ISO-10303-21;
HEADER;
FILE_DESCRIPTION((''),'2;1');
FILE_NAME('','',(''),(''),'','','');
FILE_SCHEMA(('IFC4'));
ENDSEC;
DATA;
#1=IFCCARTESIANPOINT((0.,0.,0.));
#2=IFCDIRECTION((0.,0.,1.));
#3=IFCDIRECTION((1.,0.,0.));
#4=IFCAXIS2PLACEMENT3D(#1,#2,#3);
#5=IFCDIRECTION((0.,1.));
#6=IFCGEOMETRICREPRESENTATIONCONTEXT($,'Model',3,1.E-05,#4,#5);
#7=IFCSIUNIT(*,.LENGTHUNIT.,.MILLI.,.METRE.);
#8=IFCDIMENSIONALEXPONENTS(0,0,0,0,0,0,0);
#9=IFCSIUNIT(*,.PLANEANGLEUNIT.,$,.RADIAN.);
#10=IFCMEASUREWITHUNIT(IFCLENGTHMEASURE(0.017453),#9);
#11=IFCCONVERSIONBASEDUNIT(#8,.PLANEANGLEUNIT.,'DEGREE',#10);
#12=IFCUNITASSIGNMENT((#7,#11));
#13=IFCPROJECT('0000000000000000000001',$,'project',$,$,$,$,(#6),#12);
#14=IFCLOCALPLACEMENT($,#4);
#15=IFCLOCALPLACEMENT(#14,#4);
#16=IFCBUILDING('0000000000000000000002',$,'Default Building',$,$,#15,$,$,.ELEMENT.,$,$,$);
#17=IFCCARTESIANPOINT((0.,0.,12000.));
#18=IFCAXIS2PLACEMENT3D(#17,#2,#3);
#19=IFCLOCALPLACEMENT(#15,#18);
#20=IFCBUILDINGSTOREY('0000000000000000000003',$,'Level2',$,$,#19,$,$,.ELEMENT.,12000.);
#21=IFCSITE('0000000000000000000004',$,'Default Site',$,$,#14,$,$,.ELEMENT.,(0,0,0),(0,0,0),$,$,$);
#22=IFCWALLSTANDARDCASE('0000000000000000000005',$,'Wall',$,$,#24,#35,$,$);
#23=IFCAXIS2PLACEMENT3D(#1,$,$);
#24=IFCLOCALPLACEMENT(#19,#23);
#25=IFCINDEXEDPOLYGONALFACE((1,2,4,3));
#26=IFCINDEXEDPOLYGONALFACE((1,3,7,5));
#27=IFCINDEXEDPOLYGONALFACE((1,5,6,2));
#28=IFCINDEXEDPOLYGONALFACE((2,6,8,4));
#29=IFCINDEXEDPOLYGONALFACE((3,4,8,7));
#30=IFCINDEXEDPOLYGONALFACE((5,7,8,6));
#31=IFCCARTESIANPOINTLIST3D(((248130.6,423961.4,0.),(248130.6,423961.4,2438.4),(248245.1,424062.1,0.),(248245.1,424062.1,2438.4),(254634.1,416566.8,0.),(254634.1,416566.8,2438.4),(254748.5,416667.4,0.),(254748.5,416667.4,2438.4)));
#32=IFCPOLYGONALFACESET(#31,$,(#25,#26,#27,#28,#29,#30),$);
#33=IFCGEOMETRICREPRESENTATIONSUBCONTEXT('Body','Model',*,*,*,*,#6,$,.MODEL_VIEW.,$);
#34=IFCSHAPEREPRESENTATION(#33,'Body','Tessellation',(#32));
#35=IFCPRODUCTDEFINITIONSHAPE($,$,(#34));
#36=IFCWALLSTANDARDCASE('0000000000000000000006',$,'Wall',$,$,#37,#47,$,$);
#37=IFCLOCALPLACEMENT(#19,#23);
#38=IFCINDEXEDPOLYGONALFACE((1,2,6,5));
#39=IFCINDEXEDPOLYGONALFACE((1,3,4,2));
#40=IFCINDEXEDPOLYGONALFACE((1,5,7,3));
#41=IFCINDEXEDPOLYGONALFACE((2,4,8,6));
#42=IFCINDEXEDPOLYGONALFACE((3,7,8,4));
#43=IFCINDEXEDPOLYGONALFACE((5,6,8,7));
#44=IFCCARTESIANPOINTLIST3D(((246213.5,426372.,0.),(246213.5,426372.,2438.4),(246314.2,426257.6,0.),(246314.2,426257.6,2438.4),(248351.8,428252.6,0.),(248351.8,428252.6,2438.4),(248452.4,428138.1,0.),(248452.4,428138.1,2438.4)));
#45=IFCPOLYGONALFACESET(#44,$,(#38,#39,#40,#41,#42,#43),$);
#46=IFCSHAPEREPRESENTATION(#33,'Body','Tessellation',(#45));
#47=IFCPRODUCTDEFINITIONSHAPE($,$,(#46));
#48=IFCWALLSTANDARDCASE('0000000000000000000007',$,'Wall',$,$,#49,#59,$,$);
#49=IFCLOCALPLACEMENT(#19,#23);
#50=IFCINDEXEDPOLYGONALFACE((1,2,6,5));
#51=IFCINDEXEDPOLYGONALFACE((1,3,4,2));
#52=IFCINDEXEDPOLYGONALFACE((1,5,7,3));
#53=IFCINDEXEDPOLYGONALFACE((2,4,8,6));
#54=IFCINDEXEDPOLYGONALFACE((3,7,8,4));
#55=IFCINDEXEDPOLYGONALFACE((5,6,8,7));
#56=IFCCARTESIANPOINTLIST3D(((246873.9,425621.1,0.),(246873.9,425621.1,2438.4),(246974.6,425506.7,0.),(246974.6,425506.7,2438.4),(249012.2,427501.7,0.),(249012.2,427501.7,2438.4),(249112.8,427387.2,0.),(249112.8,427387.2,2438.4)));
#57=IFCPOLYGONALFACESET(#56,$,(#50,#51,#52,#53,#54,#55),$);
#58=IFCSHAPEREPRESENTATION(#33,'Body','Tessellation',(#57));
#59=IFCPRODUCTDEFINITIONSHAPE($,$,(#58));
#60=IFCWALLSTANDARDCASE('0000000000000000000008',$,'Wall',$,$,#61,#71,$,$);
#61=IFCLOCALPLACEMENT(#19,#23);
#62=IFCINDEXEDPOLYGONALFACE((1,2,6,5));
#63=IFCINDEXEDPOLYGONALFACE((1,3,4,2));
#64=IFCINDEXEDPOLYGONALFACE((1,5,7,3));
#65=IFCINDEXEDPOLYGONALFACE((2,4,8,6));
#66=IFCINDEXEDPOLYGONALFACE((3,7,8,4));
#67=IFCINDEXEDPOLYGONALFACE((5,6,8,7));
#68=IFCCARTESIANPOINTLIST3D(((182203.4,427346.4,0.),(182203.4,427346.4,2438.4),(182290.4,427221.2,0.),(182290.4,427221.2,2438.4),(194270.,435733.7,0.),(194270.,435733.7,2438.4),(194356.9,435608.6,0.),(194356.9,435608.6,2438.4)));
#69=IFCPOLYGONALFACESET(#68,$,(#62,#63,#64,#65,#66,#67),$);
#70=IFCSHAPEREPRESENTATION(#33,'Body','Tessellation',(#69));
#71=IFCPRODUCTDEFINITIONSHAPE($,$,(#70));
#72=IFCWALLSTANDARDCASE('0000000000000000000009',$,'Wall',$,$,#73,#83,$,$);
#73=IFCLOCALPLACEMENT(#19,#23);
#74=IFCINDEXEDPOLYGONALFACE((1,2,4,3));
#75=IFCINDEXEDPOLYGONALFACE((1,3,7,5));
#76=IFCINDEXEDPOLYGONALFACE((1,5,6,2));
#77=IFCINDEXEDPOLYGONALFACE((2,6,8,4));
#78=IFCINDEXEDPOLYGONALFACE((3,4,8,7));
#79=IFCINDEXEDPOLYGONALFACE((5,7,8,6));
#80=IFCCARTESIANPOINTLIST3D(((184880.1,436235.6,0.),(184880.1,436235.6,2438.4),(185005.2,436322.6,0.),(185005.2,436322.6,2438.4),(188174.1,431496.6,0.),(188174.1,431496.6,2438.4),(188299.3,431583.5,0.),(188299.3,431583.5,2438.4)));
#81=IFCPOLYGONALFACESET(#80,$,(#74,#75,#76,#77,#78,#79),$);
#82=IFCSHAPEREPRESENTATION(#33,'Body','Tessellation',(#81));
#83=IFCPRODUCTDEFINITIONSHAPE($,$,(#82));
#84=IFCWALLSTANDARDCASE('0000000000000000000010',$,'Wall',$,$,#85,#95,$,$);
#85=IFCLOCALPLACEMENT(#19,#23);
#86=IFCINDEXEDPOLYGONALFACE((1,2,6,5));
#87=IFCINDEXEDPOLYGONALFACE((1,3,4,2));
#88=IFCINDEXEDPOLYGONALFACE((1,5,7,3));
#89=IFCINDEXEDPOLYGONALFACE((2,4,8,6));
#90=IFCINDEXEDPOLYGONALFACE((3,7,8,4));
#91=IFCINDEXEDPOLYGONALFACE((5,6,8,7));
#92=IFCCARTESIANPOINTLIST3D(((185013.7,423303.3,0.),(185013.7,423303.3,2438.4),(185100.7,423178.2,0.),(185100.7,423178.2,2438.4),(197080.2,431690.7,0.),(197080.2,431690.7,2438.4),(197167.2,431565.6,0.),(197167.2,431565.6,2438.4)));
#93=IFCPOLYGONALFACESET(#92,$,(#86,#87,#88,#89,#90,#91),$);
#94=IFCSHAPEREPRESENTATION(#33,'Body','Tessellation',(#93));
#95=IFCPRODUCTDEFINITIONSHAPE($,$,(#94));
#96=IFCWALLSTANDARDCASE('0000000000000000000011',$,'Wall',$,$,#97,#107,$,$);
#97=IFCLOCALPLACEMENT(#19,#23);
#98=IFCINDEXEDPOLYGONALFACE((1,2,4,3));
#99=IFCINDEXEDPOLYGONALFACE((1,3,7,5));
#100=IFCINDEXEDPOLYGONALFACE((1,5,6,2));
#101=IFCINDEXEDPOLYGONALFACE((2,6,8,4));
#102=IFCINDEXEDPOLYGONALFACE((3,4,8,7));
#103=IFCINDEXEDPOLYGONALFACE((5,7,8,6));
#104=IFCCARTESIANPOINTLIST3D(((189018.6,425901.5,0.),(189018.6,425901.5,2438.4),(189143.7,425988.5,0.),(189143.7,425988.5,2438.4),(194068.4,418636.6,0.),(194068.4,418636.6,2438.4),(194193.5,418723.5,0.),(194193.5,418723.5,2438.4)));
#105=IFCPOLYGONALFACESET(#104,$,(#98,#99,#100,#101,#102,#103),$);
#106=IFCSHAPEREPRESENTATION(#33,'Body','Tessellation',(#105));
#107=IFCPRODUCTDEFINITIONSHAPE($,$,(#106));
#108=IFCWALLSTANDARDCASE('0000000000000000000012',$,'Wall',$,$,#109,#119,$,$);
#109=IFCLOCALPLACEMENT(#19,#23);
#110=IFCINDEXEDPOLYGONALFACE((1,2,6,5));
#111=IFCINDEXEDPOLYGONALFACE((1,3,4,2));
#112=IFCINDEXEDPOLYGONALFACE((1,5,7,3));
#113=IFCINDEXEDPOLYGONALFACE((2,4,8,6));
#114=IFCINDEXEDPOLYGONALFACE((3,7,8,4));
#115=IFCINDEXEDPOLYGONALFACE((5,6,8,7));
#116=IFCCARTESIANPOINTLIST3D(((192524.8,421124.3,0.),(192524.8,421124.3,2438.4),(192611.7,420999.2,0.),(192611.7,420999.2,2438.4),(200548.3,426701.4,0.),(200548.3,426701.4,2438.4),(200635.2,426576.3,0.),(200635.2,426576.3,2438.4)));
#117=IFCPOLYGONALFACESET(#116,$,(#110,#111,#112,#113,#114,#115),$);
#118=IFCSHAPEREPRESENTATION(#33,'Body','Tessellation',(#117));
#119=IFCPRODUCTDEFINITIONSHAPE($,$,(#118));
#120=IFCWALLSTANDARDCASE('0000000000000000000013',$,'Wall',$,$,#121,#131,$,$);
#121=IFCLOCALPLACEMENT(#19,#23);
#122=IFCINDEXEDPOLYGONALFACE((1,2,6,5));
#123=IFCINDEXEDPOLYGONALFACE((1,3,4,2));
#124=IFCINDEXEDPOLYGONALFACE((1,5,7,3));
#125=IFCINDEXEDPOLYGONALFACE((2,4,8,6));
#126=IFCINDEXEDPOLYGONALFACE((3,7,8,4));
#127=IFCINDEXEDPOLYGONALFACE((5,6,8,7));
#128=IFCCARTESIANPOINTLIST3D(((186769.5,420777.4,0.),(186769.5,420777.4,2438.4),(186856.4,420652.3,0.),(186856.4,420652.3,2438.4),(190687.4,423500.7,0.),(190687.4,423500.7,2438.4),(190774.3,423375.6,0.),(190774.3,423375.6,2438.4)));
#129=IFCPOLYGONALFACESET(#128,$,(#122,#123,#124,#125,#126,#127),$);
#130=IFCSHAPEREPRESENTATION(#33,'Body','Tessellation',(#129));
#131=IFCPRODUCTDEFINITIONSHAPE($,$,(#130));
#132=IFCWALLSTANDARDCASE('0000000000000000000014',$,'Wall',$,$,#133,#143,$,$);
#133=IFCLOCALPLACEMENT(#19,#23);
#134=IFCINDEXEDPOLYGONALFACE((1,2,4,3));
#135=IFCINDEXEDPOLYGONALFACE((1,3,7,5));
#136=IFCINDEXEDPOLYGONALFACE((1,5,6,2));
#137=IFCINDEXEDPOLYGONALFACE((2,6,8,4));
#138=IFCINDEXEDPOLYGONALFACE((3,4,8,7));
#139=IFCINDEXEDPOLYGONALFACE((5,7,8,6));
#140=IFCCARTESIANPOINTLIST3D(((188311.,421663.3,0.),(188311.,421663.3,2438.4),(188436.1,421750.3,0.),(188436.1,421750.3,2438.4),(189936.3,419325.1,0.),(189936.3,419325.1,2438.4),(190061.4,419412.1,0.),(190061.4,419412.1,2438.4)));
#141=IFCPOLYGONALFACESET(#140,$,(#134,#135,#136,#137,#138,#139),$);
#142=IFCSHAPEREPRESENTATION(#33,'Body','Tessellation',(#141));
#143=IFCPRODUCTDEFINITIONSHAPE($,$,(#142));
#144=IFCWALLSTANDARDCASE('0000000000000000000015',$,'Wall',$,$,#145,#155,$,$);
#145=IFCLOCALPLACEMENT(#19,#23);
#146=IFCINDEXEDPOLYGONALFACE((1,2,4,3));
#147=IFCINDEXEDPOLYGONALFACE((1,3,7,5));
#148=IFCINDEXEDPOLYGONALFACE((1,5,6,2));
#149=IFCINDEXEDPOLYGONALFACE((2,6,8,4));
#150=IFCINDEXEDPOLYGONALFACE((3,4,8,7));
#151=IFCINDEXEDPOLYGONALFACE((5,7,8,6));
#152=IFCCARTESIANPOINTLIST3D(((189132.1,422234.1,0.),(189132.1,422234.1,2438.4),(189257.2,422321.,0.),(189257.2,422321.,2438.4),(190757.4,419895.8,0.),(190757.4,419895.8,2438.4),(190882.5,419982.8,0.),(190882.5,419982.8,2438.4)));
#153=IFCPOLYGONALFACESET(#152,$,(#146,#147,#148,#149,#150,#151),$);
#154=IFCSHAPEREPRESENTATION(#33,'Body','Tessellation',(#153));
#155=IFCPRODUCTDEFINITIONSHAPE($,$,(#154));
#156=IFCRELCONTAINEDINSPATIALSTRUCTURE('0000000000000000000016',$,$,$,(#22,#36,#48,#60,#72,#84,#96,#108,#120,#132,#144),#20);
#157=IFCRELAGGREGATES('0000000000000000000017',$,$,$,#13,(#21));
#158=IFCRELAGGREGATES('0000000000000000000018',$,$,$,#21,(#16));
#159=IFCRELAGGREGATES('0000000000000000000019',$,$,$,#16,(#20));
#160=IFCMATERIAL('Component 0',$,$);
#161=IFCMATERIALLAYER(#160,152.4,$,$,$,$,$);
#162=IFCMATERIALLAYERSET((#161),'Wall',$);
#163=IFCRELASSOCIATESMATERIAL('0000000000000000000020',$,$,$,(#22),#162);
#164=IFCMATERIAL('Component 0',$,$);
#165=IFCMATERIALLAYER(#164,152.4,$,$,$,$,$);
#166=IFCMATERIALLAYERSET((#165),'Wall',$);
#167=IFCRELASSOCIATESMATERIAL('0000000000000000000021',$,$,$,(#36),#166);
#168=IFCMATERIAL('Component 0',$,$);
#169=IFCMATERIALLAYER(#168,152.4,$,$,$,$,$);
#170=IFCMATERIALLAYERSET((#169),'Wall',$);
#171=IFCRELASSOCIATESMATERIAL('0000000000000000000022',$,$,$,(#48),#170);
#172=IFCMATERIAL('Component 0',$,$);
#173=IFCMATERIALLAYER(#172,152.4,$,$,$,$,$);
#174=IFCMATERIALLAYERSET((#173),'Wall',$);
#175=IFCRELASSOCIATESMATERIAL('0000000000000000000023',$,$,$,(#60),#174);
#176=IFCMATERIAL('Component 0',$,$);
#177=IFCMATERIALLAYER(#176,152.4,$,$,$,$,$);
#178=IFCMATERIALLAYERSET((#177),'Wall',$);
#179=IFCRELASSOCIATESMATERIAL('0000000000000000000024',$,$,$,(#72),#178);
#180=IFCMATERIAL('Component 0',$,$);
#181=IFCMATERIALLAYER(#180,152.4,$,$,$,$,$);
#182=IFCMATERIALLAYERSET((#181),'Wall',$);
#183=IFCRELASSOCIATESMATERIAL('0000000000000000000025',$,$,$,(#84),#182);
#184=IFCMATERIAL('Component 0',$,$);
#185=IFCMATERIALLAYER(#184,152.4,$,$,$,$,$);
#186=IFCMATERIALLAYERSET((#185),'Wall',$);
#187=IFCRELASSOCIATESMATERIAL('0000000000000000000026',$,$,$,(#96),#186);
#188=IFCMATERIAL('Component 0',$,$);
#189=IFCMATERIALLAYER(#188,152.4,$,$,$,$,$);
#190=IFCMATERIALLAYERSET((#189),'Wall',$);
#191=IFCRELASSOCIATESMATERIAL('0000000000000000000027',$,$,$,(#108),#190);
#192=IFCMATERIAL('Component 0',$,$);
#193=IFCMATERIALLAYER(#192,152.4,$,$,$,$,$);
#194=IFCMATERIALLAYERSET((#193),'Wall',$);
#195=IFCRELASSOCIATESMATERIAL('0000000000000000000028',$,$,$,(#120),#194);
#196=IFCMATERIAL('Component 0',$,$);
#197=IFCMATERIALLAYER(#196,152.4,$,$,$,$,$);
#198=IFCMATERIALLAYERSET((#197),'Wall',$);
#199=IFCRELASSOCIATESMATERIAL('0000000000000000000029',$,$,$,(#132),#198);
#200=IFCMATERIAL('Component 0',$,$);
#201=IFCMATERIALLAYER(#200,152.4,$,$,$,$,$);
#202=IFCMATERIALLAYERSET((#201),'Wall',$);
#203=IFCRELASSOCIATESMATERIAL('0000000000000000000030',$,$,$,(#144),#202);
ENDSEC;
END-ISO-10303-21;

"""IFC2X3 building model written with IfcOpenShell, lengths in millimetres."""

from ifc_helpers import new_model, entity, si_unit, converted_unit, direction, frame, origin_with_axes, place, context, subcontext, project, spatial, polyline, outline, extrude, material, layer, layer_set, layer_usage, element, save


model = new_model("IFC2X3")

# Units and contexts
model_context = context("Model", 3, precision=1e-05, world=origin_with_axes(), true_north=direction((0.0, 1.0)))
body_context = subcontext(model_context, "Body", "Model", "MODEL_VIEW")
ifc_project = project(units=[si_unit("LENGTHUNIT", "METRE", prefix="MILLI"), converted_unit("PLANEANGLEUNIT", "DEGREE", entity("IfcLengthMeasure", 0.017453), si_unit("PLANEANGLEUNIT", "RADIAN"), dimensions=[0, 0, 0, 0, 0, 0, 0])], contexts=[model_context])

# Site, building, storey
site_placement = place(None, origin_with_axes())
site = spatial("IfcSite", under=ifc_project, at=site_placement, Name="Default Site", CompositionType="ELEMENT", RefLatitude=(0, 0, 0), RefLongitude=(0, 0, 0))
building_placement = place(site_placement, origin_with_axes())
building = spatial("IfcBuilding", under=site, at=building_placement, Name="Default Building", CompositionType="ELEMENT")
storey_placement = place(building_placement, frame((0.0, 0.0, 12000.0), z_axis=(0.0, 0.0, 1.0), x_axis=(1.0, 0.0, 0.0)))
storey = spatial("IfcBuildingStorey", under=building, at=storey_placement, Name="Level2", CompositionType="ELEMENT", Elevation=12000.0)

# Walls
ifc_material_1 = material(Name="Component 0")
ifc_layer_1 = layer(ifc_material_1, 152.4)
ifc_layer_set_1 = layer_set([ifc_layer_1], Name="Wall")
ifc_layer_usage_1 = layer_usage(ifc_layer_set_1, "AXIS2", "POSITIVE", -76.2)
wall_1_placement = place(storey_placement, frame((248187.8, 424011.7, 0.0), z_axis=(0.0, 0.0, 1.0), x_axis=(0.660409, -0.750906, 0.0)))
element("IfcWallStandardCase", 1, at=wall_1_placement, inside=storey, material=ifc_layer_usage_1, Name="Wall", context=body_context, shape_type="SweptSolid", body=[
    extrude(outline(polyline([(0.0, -76.2), (0.0, 76.2), (9847.6, 76.2), (9847.6, -76.2), (0.0, -76.2)])), origin_with_axes(), (0.0, 0.0, 1.0), 2438.4),
])
ifc_material_2 = material(Name="Component 0")
ifc_layer_2 = layer(ifc_material_2, 152.4)
ifc_layer_set_2 = layer_set([ifc_layer_2], Name="Wall")
ifc_layer_usage_2 = layer_usage(ifc_layer_set_2, "AXIS2", "POSITIVE", -76.2)
wall_2_placement = place(storey_placement, frame((246206.6, 426264.5, 0.0), z_axis=(0.0, 0.0, 1.0), x_axis=(0.750906, 0.660409, 0.0)))
element("IfcWallStandardCase", 2, at=wall_2_placement, inside=storey, material=ifc_layer_usage_2, Name="Wall", context=body_context, shape_type="SweptSolid", body=[
    extrude(outline(polyline([(76.2, -76.2), (76.2, 76.2), (2923.8, 76.2), (2923.8, -76.2), (76.2, -76.2)])), origin_with_axes(), (0.0, 0.0, 1.0), 2438.4),
])
ifc_material_3 = material(Name="Component 0")
ifc_layer_3 = layer(ifc_material_3, 152.4)
ifc_layer_set_3 = layer_set([ifc_layer_3], Name="Wall")
ifc_layer_usage_3 = layer_usage(ifc_layer_set_3, "AXIS2", "POSITIVE", -76.2)
wall_3_placement = place(storey_placement, frame((246867.0, 425513.6, 0.0), z_axis=(0.0, 0.0, 1.0), x_axis=(0.750906, 0.660409, 0.0)))
element("IfcWallStandardCase", 3, at=wall_3_placement, inside=storey, material=ifc_layer_usage_3, Name="Wall", context=body_context, shape_type="SweptSolid", body=[
    extrude(outline(polyline([(76.2, -76.2), (76.2, 76.2), (2923.8, 76.2), (2923.8, -76.2), (76.2, -76.2)])), origin_with_axes(), (0.0, 0.0, 1.0), 2438.4),
])
ifc_material_4 = material(Name="Component 0")
ifc_layer_4 = layer(ifc_material_4, 152.4)
ifc_layer_set_4 = layer_set([ifc_layer_4], Name="Wall")
ifc_layer_usage_4 = layer_usage(ifc_layer_set_4, "AXIS2", "POSITIVE", -76.2)
wall_4_placement = place(storey_placement, frame((182184.3, 427240.3, 0.0), z_axis=(0.0, 0.0, 1.0), x_axis=(0.82112, 0.570755, 0.0)))
element("IfcWallStandardCase", 4, at=wall_4_placement, inside=storey, material=ifc_layer_usage_4, Name="Wall", context=body_context, shape_type="SweptSolid", body=[
    extrude(outline(polyline([(76.2, -76.2), (76.2, 76.2), (14771.4, 76.2), (14771.4, -76.2), (76.2, -76.2)])), origin_with_axes(), (0.0, 0.0, 1.0), 2438.4),
])
ifc_material_5 = material(Name="Component 0")
ifc_layer_5 = layer(ifc_material_5, 152.4)
ifc_layer_set_5 = layer_set([ifc_layer_5], Name="Wall")
ifc_layer_usage_5 = layer_usage(ifc_layer_set_5, "AXIS2", "POSITIVE", -76.2)
wall_5_placement = place(storey_placement, frame((184899.1, 436341.6, 0.0), z_axis=(0.0, 0.0, 1.0), x_axis=(0.570755, -0.82112, 0.0)))
element("IfcWallStandardCase", 5, at=wall_5_placement, inside=storey, material=ifc_layer_usage_5, Name="Wall", context=body_context, shape_type="SweptSolid", body=[
    extrude(outline(polyline([(76.2, -76.2), (76.2, 76.2), (5847.6, 76.2), (5847.6, -76.2), (76.2, -76.2)])), origin_with_axes(), (0.0, 0.0, 1.0), 2438.4),
])
ifc_material_6 = material(Name="Component 0")
ifc_layer_6 = layer(ifc_material_6, 152.4)
ifc_layer_set_6 = layer_set([ifc_layer_6], Name="Wall")
ifc_layer_usage_6 = layer_usage(ifc_layer_set_6, "AXIS2", "POSITIVE", -76.2)
wall_6_placement = place(storey_placement, frame((197186.3, 431671.6, 0.0), z_axis=(0.0, 0.0, 1.0), x_axis=(-0.82112, -0.570755, 0.0)))
element("IfcWallStandardCase", 6, at=wall_6_placement, inside=storey, material=ifc_layer_usage_6, Name="Wall", context=body_context, shape_type="SweptSolid", body=[
    extrude(outline(polyline([(76.2, -76.2), (76.2, 76.2), (14771.4, 76.2), (14771.4, -76.2), (76.2, -76.2)])), origin_with_axes(), (0.0, 0.0, 1.0), 2438.4),
])
ifc_material_7 = material(Name="Component 0")
ifc_layer_7 = layer(ifc_material_7, 152.4)
ifc_layer_set_7 = layer_set([ifc_layer_7], Name="Wall")
ifc_layer_usage_7 = layer_usage(ifc_layer_set_7, "AXIS2", "POSITIVE", -76.2)
wall_7_placement = place(storey_placement, frame((189037.7, 426007.6, 0.0), z_axis=(0.0, 0.0, 1.0), x_axis=(0.570755, -0.82112, 0.0)))
element("IfcWallStandardCase", 7, at=wall_7_placement, inside=storey, material=ifc_layer_usage_7, Name="Wall", context=body_context, shape_type="SweptSolid", body=[
    extrude(outline(polyline([(76.2, -76.2), (76.2, 76.2), (8923.8, 76.2), (8923.8, -76.2), (76.2, -76.2)])), origin_with_axes(), (0.0, 0.0, 1.0), 2438.4),
])
ifc_material_8 = material(Name="Component 0")
ifc_layer_8 = layer(ifc_material_8, 152.4)
ifc_layer_set_8 = layer_set([ifc_layer_8], Name="Wall")
ifc_layer_usage_8 = layer_usage(ifc_layer_set_8, "AXIS2", "POSITIVE", -76.2)
wall_8_placement = place(storey_placement, frame((200654.3, 426682.3, 0.0), z_axis=(0.0, 0.0, 1.0), x_axis=(-0.82112, -0.570755, 0.0)))
element("IfcWallStandardCase", 8, at=wall_8_placement, inside=storey, material=ifc_layer_usage_8, Name="Wall", context=body_context, shape_type="SweptSolid", body=[
    extrude(outline(polyline([(76.2, -76.2), (76.2, 76.2), (9847.6, 76.2), (9847.6, -76.2), (76.2, -76.2)])), origin_with_axes(), (0.0, 0.0, 1.0), 2438.4),
])
ifc_material_9 = material(Name="Component 0")
ifc_layer_9 = layer(ifc_material_9, 152.4)
ifc_layer_set_9 = layer_set([ifc_layer_9], Name="Wall")
ifc_layer_usage_9 = layer_usage(ifc_layer_set_9, "AXIS2", "POSITIVE", -76.2)
wall_9_placement = place(storey_placement, frame((186750.4, 420671.3, 0.0), z_axis=(0.0, 0.0, 1.0), x_axis=(0.82112, 0.570755, 0.0)))
element("IfcWallStandardCase", 9, at=wall_9_placement, inside=storey, material=ifc_layer_usage_9, Name="Wall", context=body_context, shape_type="SweptSolid", body=[
    extrude(outline(polyline([(76.2, -76.2), (76.2, 76.2), (4847.6, 76.2), (4847.6, -76.2), (76.2, -76.2)])), origin_with_axes(), (0.0, 0.0, 1.0), 2438.4),
])
ifc_material_10 = material(Name="Component 0")
ifc_layer_10 = layer(ifc_material_10, 152.4)
ifc_layer_set_10 = layer_set([ifc_layer_10], Name="Wall")
ifc_layer_usage_10 = layer_usage(ifc_layer_set_10, "AXIS2", "POSITIVE", -76.2)
wall_10_placement = place(storey_placement, frame((188330.1, 421769.4, 0.0), z_axis=(0.0, 0.0, 1.0), x_axis=(0.570755, -0.82112, 0.0)))
element("IfcWallStandardCase", 10, at=wall_10_placement, inside=storey, material=ifc_layer_usage_10, Name="Wall", context=body_context, shape_type="SweptSolid", body=[
    extrude(outline(polyline([(76.2, -76.2), (76.2, 76.2), (2923.8, 76.2), (2923.8, -76.2), (76.2, -76.2)])), origin_with_axes(), (0.0, 0.0, 1.0), 2438.4),
])
ifc_material_11 = material(Name="Component 0")
ifc_layer_11 = layer(ifc_material_11, 152.4)
ifc_layer_set_11 = layer_set([ifc_layer_11], Name="Wall")
ifc_layer_usage_11 = layer_usage(ifc_layer_set_11, "AXIS2", "POSITIVE", -76.2)
wall_11_placement = place(storey_placement, frame((189151.2, 422340.1, 0.0), z_axis=(0.0, 0.0, 1.0), x_axis=(0.570755, -0.82112, 0.0)))
element("IfcWallStandardCase", 11, at=wall_11_placement, inside=storey, material=ifc_layer_usage_11, Name="Wall", context=body_context, shape_type="SweptSolid", body=[
    extrude(outline(polyline([(76.2, -76.2), (76.2, 76.2), (2923.8, 76.2), (2923.8, -76.2), (76.2, -76.2)])), origin_with_axes(), (0.0, 0.0, 1.0), 2438.4),
])

save(model, "model.ifc")
